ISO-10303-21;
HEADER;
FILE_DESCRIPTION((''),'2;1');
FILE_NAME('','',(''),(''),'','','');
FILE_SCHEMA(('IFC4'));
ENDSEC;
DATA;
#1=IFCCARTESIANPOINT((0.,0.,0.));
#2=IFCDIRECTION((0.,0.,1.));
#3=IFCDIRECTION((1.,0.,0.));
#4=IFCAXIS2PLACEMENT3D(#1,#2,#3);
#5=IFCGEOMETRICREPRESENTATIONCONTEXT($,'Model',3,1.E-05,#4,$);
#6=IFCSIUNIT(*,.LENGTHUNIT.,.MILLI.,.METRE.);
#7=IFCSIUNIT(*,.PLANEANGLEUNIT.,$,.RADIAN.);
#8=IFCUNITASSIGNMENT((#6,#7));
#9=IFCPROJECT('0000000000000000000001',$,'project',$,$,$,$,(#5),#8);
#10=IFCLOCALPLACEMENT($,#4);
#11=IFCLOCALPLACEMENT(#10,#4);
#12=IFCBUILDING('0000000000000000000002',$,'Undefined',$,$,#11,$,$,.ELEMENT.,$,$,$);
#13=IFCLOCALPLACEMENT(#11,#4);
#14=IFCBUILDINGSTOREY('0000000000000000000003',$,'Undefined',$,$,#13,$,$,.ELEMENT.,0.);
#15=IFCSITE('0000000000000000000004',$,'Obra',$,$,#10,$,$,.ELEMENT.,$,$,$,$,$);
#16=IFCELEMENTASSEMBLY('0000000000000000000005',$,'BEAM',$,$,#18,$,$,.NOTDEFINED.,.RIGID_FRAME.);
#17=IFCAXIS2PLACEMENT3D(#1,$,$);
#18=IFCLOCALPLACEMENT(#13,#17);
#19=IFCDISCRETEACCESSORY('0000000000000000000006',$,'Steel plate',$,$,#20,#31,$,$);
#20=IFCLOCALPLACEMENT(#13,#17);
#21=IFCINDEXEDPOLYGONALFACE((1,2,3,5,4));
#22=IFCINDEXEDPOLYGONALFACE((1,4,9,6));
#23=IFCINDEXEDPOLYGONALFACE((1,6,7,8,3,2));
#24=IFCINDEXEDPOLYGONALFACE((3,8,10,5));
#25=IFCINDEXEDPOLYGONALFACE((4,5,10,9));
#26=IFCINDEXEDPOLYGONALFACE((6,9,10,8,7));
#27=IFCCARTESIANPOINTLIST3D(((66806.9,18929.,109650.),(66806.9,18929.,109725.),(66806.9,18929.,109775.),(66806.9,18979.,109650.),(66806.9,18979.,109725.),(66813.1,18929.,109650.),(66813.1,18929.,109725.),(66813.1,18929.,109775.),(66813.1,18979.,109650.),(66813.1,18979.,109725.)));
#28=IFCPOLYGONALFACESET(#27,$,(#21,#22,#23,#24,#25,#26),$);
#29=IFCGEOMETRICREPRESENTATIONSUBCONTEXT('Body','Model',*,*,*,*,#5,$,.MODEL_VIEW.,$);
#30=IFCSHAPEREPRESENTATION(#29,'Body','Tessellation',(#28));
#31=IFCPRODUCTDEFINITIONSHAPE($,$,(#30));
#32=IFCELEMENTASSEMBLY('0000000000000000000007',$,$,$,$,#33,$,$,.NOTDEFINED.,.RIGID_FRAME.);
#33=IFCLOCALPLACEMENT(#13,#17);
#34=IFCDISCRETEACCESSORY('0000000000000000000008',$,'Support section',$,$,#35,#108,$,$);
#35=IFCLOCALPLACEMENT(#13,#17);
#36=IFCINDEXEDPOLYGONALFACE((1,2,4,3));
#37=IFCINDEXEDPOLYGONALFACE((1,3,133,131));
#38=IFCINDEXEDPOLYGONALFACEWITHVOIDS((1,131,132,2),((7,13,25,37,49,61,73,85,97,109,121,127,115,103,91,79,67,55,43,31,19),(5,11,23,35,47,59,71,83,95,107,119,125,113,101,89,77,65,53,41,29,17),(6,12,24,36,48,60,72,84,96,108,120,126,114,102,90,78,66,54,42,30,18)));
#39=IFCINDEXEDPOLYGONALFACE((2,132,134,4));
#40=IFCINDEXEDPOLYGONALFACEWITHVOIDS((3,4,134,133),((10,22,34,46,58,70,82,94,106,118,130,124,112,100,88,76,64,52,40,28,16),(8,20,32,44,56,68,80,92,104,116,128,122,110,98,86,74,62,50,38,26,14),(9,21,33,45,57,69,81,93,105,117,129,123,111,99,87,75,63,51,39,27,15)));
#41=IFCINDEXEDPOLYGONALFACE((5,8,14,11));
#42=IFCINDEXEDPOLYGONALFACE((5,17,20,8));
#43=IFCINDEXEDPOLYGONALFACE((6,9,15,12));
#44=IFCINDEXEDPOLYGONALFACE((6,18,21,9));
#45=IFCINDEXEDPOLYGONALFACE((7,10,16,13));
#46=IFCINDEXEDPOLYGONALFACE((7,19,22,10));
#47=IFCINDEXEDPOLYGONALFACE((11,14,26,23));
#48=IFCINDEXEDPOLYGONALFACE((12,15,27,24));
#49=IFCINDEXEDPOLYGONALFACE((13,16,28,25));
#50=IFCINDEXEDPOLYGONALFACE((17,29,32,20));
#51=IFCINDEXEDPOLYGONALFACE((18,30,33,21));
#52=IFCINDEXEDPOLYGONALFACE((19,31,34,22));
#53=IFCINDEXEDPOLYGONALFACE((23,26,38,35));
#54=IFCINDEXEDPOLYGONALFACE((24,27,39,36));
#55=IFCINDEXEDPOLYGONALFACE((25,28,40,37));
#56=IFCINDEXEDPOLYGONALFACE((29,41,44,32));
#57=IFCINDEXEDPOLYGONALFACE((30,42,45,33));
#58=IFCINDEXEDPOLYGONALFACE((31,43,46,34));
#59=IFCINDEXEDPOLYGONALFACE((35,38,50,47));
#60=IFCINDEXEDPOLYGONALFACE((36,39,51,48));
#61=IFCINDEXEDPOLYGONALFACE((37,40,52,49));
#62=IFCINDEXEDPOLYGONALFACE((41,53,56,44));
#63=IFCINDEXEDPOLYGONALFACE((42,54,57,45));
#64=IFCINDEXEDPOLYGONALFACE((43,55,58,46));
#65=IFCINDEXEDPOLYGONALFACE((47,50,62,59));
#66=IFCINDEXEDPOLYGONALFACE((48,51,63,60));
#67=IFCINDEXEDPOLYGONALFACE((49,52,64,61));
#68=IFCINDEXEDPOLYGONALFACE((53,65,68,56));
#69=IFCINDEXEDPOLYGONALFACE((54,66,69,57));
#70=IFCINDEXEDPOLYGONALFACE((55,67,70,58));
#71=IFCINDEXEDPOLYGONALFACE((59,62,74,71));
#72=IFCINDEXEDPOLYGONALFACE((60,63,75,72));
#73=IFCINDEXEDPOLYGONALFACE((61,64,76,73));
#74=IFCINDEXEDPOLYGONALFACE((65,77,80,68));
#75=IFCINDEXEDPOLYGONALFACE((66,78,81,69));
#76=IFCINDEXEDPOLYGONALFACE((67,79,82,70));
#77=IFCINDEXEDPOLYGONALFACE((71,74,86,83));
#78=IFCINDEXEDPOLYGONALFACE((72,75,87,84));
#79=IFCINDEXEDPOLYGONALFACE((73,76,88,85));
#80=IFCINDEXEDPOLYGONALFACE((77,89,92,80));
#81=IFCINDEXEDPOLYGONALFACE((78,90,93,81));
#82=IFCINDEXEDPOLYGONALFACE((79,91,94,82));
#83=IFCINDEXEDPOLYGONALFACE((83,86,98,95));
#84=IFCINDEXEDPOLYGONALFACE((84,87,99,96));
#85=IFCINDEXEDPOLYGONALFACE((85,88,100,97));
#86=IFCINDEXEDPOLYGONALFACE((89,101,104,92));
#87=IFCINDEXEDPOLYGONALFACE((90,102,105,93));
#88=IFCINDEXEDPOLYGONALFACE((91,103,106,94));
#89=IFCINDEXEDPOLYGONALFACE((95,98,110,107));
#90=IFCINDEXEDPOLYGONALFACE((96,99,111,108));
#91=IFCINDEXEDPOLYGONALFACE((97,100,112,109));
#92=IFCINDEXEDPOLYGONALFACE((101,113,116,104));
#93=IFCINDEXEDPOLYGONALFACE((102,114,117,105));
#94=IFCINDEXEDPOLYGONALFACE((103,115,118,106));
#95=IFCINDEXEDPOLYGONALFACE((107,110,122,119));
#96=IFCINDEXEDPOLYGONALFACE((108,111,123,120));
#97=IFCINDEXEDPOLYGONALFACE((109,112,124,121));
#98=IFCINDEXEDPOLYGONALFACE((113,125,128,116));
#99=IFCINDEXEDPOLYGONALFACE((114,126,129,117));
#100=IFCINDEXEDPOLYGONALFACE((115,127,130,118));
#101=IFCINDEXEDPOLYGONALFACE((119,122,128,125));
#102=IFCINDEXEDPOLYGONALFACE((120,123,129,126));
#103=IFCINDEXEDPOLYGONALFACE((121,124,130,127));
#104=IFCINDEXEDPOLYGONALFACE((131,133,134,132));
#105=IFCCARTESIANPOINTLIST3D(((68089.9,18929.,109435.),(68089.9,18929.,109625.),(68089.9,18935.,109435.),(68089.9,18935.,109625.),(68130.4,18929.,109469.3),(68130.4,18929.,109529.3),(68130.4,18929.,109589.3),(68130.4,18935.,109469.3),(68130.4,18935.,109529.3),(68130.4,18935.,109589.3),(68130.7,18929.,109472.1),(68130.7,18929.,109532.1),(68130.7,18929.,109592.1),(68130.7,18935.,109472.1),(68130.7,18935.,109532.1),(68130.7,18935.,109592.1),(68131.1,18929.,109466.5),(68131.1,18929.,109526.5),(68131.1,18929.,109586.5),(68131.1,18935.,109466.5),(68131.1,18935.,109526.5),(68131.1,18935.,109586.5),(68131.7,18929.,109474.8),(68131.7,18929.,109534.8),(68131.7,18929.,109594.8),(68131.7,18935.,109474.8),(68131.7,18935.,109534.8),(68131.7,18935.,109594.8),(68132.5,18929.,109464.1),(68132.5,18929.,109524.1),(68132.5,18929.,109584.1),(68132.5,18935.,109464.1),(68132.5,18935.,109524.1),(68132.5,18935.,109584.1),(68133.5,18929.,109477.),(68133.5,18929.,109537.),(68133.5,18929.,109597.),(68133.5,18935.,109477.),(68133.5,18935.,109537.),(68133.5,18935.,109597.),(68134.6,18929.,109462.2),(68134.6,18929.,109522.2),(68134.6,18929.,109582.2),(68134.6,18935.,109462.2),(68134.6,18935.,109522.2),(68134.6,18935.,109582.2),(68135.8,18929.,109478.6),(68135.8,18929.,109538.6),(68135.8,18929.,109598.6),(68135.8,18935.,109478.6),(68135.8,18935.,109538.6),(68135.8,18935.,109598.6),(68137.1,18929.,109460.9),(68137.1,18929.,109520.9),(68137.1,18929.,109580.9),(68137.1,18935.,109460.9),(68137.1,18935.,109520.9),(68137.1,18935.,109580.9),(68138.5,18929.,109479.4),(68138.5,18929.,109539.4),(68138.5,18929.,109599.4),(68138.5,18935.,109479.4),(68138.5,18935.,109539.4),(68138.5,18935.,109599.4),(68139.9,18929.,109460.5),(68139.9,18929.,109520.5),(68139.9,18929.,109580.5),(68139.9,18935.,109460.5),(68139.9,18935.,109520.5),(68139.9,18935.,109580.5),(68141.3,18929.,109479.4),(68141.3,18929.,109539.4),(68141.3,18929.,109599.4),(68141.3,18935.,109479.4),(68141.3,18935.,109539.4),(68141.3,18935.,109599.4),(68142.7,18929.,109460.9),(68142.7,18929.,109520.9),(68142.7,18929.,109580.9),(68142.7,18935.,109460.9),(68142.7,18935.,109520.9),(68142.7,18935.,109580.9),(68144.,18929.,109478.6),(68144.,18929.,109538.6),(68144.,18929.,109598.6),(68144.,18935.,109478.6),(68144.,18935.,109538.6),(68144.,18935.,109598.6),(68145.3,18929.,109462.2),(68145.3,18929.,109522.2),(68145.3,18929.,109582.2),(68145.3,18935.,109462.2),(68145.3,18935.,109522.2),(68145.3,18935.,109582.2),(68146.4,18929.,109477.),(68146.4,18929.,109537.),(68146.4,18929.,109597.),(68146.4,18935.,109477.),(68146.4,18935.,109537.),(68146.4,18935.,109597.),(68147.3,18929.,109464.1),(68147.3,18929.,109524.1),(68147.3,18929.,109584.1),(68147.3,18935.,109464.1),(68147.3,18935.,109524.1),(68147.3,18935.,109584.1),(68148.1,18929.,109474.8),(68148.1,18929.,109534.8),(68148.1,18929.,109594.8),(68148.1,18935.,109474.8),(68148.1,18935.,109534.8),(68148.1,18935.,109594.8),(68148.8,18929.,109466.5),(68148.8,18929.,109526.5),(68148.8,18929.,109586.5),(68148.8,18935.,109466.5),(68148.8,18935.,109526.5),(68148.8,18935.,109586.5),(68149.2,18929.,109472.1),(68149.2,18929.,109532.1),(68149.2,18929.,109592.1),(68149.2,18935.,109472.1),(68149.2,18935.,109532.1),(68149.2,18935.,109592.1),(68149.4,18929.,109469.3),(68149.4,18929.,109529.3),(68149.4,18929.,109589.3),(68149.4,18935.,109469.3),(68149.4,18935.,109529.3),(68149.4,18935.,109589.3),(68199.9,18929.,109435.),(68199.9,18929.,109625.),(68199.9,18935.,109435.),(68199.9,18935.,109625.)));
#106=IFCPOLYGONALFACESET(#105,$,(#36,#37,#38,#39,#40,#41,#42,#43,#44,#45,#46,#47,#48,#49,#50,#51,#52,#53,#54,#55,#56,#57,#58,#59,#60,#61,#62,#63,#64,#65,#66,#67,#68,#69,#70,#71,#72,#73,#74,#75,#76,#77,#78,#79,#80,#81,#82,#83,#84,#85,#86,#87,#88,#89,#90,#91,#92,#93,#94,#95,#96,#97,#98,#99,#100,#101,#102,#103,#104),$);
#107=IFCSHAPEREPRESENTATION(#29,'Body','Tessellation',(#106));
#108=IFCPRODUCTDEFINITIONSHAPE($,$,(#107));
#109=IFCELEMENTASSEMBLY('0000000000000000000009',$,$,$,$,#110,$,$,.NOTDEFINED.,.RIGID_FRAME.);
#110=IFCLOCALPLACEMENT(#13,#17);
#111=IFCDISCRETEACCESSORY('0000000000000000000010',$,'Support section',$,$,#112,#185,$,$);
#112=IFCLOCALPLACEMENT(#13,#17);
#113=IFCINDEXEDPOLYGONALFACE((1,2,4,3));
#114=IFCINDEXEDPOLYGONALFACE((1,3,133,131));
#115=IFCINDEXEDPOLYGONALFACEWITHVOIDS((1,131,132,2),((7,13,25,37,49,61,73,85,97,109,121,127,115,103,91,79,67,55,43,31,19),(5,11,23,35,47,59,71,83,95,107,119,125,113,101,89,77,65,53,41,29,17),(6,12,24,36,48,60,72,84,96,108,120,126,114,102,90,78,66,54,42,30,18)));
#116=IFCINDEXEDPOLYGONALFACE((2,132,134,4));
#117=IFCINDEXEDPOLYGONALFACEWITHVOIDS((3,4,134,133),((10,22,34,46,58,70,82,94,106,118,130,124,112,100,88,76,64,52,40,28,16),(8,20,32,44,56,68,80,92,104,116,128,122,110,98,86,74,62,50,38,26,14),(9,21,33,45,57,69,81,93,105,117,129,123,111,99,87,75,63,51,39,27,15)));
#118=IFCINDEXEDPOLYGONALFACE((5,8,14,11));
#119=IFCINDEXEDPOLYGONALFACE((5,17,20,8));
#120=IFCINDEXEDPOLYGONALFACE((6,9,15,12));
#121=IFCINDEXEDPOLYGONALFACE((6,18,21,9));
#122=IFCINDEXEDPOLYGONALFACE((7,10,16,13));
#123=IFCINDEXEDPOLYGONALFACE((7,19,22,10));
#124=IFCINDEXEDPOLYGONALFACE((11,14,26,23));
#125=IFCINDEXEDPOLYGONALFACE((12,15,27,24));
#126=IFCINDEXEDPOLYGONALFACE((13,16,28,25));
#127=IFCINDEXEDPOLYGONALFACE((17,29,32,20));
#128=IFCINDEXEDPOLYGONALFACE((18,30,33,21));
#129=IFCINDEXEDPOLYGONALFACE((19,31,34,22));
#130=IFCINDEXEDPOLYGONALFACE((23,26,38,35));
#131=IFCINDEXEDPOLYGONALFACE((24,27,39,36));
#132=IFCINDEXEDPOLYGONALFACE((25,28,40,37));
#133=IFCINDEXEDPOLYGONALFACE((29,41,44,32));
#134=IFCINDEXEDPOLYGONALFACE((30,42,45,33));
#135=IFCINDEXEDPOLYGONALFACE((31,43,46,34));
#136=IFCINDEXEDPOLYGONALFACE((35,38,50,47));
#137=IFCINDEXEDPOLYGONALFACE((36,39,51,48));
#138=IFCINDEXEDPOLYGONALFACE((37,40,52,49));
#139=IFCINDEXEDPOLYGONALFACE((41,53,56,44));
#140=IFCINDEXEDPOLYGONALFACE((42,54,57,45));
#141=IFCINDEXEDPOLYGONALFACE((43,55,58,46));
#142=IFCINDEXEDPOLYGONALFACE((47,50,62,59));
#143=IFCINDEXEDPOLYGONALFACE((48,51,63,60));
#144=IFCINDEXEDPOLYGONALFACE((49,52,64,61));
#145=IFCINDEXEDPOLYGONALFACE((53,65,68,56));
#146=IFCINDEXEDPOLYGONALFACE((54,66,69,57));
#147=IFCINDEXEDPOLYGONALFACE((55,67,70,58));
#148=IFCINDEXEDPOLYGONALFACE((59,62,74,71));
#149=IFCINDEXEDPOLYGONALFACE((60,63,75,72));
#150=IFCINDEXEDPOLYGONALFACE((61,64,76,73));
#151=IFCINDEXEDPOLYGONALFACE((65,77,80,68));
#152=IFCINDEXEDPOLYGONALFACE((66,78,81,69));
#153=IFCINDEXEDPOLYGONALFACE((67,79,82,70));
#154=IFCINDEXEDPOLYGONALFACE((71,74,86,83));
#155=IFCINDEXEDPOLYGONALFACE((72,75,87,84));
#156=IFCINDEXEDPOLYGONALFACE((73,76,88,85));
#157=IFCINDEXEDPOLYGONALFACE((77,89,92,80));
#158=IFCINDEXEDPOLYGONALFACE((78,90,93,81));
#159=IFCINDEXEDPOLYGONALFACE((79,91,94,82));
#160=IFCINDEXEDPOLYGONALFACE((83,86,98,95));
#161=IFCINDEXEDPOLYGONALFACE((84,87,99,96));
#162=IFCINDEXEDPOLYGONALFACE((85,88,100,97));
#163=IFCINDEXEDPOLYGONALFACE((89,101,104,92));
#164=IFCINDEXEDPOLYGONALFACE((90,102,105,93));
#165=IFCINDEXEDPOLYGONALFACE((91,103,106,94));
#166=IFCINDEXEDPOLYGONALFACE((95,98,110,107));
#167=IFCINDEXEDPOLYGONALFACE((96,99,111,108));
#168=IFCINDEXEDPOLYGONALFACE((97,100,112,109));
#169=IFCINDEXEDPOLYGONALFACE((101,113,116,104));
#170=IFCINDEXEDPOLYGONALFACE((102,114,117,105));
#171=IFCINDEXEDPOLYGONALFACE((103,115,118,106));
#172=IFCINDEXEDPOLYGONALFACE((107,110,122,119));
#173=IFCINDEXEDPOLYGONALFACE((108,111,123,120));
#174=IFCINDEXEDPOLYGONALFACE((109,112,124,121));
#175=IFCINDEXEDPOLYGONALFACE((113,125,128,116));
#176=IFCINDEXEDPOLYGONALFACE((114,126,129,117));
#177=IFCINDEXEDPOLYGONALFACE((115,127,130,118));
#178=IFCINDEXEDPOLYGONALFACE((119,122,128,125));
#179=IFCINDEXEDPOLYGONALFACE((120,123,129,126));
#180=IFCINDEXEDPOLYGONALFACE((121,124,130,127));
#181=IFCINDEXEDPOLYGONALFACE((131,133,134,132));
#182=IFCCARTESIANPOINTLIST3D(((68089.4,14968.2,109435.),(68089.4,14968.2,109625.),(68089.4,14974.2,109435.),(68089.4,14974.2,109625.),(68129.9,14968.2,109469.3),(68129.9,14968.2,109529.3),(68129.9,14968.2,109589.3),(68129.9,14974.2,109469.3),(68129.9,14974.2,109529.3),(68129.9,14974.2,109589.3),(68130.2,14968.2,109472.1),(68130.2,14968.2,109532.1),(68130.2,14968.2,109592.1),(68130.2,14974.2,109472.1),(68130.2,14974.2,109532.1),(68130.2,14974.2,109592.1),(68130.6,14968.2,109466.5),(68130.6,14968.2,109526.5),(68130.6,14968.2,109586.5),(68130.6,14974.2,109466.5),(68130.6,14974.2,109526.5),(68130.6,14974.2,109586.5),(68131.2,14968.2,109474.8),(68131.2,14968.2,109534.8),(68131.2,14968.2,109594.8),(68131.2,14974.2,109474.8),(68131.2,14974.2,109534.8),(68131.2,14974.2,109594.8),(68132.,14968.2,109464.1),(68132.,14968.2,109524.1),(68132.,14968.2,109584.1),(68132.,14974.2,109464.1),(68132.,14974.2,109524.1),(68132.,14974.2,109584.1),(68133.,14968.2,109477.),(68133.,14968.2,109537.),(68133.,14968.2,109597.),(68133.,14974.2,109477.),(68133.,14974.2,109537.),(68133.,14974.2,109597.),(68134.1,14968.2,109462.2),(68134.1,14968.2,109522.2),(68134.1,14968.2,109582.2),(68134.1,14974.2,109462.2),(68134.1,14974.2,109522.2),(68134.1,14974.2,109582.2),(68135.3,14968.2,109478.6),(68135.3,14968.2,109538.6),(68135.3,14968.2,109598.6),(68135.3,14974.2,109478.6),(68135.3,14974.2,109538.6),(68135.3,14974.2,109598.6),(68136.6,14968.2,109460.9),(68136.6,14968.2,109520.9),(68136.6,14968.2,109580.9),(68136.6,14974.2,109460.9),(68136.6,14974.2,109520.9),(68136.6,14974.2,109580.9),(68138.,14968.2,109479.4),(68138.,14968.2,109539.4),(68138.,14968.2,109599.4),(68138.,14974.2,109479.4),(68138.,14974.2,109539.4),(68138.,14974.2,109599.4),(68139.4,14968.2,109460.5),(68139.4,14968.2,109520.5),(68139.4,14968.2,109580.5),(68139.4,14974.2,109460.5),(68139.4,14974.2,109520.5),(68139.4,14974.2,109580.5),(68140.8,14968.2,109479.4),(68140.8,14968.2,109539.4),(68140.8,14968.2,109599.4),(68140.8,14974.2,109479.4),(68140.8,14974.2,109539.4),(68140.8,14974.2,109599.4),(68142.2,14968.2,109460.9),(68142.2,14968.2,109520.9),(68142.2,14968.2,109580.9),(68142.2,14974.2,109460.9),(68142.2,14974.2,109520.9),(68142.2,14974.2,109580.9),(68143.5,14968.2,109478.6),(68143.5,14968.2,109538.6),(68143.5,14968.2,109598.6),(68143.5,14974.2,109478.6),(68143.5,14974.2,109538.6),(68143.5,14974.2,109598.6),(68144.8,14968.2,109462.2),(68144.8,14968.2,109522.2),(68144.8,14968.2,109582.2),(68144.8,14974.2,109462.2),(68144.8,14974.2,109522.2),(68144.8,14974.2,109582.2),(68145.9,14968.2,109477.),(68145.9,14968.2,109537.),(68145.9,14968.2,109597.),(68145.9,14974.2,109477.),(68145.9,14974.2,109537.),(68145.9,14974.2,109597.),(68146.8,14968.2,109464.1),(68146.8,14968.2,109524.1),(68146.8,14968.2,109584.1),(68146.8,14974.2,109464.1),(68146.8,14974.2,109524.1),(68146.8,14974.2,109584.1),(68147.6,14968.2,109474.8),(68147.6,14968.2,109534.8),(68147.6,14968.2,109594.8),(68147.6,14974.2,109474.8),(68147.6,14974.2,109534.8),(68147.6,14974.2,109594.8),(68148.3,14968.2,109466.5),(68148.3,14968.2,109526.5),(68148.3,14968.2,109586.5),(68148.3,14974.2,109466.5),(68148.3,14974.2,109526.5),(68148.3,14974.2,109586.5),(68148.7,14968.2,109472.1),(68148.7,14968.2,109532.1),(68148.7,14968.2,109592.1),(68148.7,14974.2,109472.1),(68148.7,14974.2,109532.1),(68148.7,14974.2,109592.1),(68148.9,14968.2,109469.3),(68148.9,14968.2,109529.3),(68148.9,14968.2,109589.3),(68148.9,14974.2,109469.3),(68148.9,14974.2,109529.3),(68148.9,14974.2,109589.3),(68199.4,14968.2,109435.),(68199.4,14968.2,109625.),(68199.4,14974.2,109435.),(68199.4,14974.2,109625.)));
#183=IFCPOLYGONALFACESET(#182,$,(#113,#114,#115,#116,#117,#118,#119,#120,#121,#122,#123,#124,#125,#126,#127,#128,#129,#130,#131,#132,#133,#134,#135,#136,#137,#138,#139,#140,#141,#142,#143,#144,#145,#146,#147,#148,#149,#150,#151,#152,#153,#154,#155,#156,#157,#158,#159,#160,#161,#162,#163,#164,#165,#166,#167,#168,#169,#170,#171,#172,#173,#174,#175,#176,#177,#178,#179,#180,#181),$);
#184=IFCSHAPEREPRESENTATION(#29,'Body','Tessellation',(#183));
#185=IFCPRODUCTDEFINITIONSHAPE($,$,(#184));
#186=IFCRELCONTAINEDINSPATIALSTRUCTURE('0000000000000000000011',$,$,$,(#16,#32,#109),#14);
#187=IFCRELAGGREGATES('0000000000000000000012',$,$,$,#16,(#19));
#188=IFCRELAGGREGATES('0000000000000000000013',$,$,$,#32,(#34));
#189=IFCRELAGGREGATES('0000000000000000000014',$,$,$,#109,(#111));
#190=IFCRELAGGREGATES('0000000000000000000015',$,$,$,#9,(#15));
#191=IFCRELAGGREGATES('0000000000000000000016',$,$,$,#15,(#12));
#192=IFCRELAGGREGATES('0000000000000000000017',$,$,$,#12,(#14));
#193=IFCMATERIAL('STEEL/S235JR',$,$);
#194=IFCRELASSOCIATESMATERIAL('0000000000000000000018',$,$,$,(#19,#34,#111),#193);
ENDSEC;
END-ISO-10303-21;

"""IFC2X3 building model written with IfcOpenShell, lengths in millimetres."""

from ifc_helpers import new_model, si_unit, frame, origin_with_axes, origin_2d_with_axis, place, context, subcontext, project, spatial, polyline, rectangle, circle, outline, extrude, source, transform, mapped, material, element, aggregate, save


model = new_model("IFC2X3")

# Units and contexts
model_context = context("Model", 3, precision=1e-05, world=origin_with_axes())
body_context = subcontext(model_context, "Body", "Model", "MODEL_VIEW")
ifc_project = project(units=[si_unit("LENGTHUNIT", "METRE", prefix="MILLI"), si_unit("PLANEANGLEUNIT", "RADIAN")], contexts=[model_context])

# Site, building, storey
site_placement = place(None, origin_with_axes())
site = spatial("IfcSite", under=ifc_project, at=site_placement, Name="Obra", CompositionType="ELEMENT")
building_placement = place(site_placement, origin_with_axes())
building = spatial("IfcBuilding", under=site, at=building_placement, Name="Undefined", CompositionType="ELEMENT")
storey_placement = place(building_placement, origin_with_axes())
storey = spatial("IfcBuildingStorey", under=building, at=storey_placement, Name="Undefined", CompositionType="ELEMENT", Elevation=0.0)

# Element assembly
assembly_1_placement = place(storey_placement, origin_with_axes())
assembly_1 = element("IfcElementAssembly", 1, at=assembly_1_placement, inside=storey, Name="BEAM", AssemblyPlace="NOTDEFINED", PredefinedType="RIGID_FRAME")
ifc_material_1 = material(Name="STEEL/S235JR")

# Discrete accessory
discrete_accessory_1_placement = place(assembly_1_placement, frame((66810.0, 18929.0, 109725.0), z_axis=(1.0, 0.0, 0.0), x_axis=(0.0, 0.0, -1.0)))
discrete_accessory_1 = element("IfcDiscreteAccessory", 2, at=discrete_accessory_1_placement, material=ifc_material_1, Name="Steel plate", context=body_context, shape_type="SweptSolid", body=[
    extrude(outline(polyline([(0.0, 0.0), (75.0, 0.0), (75.0, 50.0), (0.0, 50.0), (-75.0, -25.0), (-75.0, 0.0), (0.0, 0.0)])), frame((0.0, 0.0, -3.1), z_axis=(0.0, 0.0, 1.0), x_axis=(1.0, 0.0, 0.0)), (0.0, 0.0, 1.0), 6.2),
])
aggregate(assembly_1, [discrete_accessory_1])

# Element assemblies, discrete accessories, openings
assembly_2_placement = place(storey_placement, origin_with_axes())
assembly_2 = element("IfcElementAssembly", 3, at=assembly_2_placement, inside=storey, AssemblyPlace="NOTDEFINED", PredefinedType="RIGID_FRAME")
discrete_accessory_2_placement = place(assembly_2_placement, frame((68144.9, 18932.0, 109435.0), z_axis=(0.0, 0.0, 1.0), x_axis=(1.0, -0.000126, 0.0)))
discrete_accessory_2 = element("IfcDiscreteAccessory", 4, at=discrete_accessory_2_placement, material=ifc_material_1, Name="Support section", context=body_context, shape_type="SweptSolid", body=[
    extrude(rectangle(XDim=6.0, YDim=110.0, at=origin_2d_with_axis()), frame((0.0, 0.0, 190.0), z_axis=(0.0, 0.0, -1.0), x_axis=(0.0, 1.0, 0.0)), (0.0, 0.0, 1.0), 190.0),
])
shared_shape_1 = source(origin_with_axes(), body_context, "Body", "SweptSolid", [
    extrude(circle(Radius=9.5, at=origin_2d_with_axis()), frame((0.0, -9.2, 0.0), z_axis=(0.0, 1.0, 0.0), x_axis=(1.0, 0.0, 0.0)), (0.0, 0.0, 1.0), 6.2),
])
opening_1_placement = place(assembly_2_placement, frame((68189.9, 18925.9, 109650.0), z_axis=(-1.0, 0.000126, 0.0), x_axis=(0.0, 0.0, -1.0)))
element("IfcOpeningElement", 5, at=opening_1_placement, cuts=discrete_accessory_2, ObjectType="Opening", context=body_context, shape_type="MappedRepresentation", body=[
    mapped(shared_shape_1, transform((60.0, 0.0, 50.0))),
    mapped(shared_shape_1, transform((120.0, 0.0, 50.0))),
    mapped(shared_shape_1, transform((180.0, 0.0, 50.0))),
])
aggregate(assembly_2, [discrete_accessory_2])
assembly_3_placement = place(storey_placement, origin_with_axes())
assembly_3 = element("IfcElementAssembly", 6, at=assembly_3_placement, inside=storey, AssemblyPlace="NOTDEFINED", PredefinedType="RIGID_FRAME")
discrete_accessory_3_placement = place(assembly_3_placement, frame((68144.4, 14971.2, 109435.0), z_axis=(0.0, 0.0, 1.0), x_axis=(1.0, -0.000126, 0.0)))
discrete_accessory_3 = element("IfcDiscreteAccessory", 7, at=discrete_accessory_3_placement, material=ifc_material_1, Name="Support section", context=body_context, shape_type="SweptSolid", body=[
    extrude(rectangle(XDim=6.0, YDim=110.0, at=origin_2d_with_axis()), frame((0.0, 0.0, 190.0), z_axis=(0.0, 0.0, -1.0), x_axis=(0.0, 1.0, 0.0)), (0.0, 0.0, 1.0), 190.0),
])
opening_2_placement = place(assembly_3_placement, frame((68189.4, 14965.1, 109650.0), z_axis=(-1.0, 0.000126, 0.0), x_axis=(0.0, 0.0, -1.0)))
element("IfcOpeningElement", 8, at=opening_2_placement, cuts=discrete_accessory_3, ObjectType="Opening", context=body_context, shape_type="MappedRepresentation", body=[
    mapped(shared_shape_1, transform((60.0, 0.0, 50.0))),
    mapped(shared_shape_1, transform((120.0, 0.0, 50.0))),
    mapped(shared_shape_1, transform((180.0, 0.0, 50.0))),
])
aggregate(assembly_3, [discrete_accessory_3])

save(model, "model.ifc")
